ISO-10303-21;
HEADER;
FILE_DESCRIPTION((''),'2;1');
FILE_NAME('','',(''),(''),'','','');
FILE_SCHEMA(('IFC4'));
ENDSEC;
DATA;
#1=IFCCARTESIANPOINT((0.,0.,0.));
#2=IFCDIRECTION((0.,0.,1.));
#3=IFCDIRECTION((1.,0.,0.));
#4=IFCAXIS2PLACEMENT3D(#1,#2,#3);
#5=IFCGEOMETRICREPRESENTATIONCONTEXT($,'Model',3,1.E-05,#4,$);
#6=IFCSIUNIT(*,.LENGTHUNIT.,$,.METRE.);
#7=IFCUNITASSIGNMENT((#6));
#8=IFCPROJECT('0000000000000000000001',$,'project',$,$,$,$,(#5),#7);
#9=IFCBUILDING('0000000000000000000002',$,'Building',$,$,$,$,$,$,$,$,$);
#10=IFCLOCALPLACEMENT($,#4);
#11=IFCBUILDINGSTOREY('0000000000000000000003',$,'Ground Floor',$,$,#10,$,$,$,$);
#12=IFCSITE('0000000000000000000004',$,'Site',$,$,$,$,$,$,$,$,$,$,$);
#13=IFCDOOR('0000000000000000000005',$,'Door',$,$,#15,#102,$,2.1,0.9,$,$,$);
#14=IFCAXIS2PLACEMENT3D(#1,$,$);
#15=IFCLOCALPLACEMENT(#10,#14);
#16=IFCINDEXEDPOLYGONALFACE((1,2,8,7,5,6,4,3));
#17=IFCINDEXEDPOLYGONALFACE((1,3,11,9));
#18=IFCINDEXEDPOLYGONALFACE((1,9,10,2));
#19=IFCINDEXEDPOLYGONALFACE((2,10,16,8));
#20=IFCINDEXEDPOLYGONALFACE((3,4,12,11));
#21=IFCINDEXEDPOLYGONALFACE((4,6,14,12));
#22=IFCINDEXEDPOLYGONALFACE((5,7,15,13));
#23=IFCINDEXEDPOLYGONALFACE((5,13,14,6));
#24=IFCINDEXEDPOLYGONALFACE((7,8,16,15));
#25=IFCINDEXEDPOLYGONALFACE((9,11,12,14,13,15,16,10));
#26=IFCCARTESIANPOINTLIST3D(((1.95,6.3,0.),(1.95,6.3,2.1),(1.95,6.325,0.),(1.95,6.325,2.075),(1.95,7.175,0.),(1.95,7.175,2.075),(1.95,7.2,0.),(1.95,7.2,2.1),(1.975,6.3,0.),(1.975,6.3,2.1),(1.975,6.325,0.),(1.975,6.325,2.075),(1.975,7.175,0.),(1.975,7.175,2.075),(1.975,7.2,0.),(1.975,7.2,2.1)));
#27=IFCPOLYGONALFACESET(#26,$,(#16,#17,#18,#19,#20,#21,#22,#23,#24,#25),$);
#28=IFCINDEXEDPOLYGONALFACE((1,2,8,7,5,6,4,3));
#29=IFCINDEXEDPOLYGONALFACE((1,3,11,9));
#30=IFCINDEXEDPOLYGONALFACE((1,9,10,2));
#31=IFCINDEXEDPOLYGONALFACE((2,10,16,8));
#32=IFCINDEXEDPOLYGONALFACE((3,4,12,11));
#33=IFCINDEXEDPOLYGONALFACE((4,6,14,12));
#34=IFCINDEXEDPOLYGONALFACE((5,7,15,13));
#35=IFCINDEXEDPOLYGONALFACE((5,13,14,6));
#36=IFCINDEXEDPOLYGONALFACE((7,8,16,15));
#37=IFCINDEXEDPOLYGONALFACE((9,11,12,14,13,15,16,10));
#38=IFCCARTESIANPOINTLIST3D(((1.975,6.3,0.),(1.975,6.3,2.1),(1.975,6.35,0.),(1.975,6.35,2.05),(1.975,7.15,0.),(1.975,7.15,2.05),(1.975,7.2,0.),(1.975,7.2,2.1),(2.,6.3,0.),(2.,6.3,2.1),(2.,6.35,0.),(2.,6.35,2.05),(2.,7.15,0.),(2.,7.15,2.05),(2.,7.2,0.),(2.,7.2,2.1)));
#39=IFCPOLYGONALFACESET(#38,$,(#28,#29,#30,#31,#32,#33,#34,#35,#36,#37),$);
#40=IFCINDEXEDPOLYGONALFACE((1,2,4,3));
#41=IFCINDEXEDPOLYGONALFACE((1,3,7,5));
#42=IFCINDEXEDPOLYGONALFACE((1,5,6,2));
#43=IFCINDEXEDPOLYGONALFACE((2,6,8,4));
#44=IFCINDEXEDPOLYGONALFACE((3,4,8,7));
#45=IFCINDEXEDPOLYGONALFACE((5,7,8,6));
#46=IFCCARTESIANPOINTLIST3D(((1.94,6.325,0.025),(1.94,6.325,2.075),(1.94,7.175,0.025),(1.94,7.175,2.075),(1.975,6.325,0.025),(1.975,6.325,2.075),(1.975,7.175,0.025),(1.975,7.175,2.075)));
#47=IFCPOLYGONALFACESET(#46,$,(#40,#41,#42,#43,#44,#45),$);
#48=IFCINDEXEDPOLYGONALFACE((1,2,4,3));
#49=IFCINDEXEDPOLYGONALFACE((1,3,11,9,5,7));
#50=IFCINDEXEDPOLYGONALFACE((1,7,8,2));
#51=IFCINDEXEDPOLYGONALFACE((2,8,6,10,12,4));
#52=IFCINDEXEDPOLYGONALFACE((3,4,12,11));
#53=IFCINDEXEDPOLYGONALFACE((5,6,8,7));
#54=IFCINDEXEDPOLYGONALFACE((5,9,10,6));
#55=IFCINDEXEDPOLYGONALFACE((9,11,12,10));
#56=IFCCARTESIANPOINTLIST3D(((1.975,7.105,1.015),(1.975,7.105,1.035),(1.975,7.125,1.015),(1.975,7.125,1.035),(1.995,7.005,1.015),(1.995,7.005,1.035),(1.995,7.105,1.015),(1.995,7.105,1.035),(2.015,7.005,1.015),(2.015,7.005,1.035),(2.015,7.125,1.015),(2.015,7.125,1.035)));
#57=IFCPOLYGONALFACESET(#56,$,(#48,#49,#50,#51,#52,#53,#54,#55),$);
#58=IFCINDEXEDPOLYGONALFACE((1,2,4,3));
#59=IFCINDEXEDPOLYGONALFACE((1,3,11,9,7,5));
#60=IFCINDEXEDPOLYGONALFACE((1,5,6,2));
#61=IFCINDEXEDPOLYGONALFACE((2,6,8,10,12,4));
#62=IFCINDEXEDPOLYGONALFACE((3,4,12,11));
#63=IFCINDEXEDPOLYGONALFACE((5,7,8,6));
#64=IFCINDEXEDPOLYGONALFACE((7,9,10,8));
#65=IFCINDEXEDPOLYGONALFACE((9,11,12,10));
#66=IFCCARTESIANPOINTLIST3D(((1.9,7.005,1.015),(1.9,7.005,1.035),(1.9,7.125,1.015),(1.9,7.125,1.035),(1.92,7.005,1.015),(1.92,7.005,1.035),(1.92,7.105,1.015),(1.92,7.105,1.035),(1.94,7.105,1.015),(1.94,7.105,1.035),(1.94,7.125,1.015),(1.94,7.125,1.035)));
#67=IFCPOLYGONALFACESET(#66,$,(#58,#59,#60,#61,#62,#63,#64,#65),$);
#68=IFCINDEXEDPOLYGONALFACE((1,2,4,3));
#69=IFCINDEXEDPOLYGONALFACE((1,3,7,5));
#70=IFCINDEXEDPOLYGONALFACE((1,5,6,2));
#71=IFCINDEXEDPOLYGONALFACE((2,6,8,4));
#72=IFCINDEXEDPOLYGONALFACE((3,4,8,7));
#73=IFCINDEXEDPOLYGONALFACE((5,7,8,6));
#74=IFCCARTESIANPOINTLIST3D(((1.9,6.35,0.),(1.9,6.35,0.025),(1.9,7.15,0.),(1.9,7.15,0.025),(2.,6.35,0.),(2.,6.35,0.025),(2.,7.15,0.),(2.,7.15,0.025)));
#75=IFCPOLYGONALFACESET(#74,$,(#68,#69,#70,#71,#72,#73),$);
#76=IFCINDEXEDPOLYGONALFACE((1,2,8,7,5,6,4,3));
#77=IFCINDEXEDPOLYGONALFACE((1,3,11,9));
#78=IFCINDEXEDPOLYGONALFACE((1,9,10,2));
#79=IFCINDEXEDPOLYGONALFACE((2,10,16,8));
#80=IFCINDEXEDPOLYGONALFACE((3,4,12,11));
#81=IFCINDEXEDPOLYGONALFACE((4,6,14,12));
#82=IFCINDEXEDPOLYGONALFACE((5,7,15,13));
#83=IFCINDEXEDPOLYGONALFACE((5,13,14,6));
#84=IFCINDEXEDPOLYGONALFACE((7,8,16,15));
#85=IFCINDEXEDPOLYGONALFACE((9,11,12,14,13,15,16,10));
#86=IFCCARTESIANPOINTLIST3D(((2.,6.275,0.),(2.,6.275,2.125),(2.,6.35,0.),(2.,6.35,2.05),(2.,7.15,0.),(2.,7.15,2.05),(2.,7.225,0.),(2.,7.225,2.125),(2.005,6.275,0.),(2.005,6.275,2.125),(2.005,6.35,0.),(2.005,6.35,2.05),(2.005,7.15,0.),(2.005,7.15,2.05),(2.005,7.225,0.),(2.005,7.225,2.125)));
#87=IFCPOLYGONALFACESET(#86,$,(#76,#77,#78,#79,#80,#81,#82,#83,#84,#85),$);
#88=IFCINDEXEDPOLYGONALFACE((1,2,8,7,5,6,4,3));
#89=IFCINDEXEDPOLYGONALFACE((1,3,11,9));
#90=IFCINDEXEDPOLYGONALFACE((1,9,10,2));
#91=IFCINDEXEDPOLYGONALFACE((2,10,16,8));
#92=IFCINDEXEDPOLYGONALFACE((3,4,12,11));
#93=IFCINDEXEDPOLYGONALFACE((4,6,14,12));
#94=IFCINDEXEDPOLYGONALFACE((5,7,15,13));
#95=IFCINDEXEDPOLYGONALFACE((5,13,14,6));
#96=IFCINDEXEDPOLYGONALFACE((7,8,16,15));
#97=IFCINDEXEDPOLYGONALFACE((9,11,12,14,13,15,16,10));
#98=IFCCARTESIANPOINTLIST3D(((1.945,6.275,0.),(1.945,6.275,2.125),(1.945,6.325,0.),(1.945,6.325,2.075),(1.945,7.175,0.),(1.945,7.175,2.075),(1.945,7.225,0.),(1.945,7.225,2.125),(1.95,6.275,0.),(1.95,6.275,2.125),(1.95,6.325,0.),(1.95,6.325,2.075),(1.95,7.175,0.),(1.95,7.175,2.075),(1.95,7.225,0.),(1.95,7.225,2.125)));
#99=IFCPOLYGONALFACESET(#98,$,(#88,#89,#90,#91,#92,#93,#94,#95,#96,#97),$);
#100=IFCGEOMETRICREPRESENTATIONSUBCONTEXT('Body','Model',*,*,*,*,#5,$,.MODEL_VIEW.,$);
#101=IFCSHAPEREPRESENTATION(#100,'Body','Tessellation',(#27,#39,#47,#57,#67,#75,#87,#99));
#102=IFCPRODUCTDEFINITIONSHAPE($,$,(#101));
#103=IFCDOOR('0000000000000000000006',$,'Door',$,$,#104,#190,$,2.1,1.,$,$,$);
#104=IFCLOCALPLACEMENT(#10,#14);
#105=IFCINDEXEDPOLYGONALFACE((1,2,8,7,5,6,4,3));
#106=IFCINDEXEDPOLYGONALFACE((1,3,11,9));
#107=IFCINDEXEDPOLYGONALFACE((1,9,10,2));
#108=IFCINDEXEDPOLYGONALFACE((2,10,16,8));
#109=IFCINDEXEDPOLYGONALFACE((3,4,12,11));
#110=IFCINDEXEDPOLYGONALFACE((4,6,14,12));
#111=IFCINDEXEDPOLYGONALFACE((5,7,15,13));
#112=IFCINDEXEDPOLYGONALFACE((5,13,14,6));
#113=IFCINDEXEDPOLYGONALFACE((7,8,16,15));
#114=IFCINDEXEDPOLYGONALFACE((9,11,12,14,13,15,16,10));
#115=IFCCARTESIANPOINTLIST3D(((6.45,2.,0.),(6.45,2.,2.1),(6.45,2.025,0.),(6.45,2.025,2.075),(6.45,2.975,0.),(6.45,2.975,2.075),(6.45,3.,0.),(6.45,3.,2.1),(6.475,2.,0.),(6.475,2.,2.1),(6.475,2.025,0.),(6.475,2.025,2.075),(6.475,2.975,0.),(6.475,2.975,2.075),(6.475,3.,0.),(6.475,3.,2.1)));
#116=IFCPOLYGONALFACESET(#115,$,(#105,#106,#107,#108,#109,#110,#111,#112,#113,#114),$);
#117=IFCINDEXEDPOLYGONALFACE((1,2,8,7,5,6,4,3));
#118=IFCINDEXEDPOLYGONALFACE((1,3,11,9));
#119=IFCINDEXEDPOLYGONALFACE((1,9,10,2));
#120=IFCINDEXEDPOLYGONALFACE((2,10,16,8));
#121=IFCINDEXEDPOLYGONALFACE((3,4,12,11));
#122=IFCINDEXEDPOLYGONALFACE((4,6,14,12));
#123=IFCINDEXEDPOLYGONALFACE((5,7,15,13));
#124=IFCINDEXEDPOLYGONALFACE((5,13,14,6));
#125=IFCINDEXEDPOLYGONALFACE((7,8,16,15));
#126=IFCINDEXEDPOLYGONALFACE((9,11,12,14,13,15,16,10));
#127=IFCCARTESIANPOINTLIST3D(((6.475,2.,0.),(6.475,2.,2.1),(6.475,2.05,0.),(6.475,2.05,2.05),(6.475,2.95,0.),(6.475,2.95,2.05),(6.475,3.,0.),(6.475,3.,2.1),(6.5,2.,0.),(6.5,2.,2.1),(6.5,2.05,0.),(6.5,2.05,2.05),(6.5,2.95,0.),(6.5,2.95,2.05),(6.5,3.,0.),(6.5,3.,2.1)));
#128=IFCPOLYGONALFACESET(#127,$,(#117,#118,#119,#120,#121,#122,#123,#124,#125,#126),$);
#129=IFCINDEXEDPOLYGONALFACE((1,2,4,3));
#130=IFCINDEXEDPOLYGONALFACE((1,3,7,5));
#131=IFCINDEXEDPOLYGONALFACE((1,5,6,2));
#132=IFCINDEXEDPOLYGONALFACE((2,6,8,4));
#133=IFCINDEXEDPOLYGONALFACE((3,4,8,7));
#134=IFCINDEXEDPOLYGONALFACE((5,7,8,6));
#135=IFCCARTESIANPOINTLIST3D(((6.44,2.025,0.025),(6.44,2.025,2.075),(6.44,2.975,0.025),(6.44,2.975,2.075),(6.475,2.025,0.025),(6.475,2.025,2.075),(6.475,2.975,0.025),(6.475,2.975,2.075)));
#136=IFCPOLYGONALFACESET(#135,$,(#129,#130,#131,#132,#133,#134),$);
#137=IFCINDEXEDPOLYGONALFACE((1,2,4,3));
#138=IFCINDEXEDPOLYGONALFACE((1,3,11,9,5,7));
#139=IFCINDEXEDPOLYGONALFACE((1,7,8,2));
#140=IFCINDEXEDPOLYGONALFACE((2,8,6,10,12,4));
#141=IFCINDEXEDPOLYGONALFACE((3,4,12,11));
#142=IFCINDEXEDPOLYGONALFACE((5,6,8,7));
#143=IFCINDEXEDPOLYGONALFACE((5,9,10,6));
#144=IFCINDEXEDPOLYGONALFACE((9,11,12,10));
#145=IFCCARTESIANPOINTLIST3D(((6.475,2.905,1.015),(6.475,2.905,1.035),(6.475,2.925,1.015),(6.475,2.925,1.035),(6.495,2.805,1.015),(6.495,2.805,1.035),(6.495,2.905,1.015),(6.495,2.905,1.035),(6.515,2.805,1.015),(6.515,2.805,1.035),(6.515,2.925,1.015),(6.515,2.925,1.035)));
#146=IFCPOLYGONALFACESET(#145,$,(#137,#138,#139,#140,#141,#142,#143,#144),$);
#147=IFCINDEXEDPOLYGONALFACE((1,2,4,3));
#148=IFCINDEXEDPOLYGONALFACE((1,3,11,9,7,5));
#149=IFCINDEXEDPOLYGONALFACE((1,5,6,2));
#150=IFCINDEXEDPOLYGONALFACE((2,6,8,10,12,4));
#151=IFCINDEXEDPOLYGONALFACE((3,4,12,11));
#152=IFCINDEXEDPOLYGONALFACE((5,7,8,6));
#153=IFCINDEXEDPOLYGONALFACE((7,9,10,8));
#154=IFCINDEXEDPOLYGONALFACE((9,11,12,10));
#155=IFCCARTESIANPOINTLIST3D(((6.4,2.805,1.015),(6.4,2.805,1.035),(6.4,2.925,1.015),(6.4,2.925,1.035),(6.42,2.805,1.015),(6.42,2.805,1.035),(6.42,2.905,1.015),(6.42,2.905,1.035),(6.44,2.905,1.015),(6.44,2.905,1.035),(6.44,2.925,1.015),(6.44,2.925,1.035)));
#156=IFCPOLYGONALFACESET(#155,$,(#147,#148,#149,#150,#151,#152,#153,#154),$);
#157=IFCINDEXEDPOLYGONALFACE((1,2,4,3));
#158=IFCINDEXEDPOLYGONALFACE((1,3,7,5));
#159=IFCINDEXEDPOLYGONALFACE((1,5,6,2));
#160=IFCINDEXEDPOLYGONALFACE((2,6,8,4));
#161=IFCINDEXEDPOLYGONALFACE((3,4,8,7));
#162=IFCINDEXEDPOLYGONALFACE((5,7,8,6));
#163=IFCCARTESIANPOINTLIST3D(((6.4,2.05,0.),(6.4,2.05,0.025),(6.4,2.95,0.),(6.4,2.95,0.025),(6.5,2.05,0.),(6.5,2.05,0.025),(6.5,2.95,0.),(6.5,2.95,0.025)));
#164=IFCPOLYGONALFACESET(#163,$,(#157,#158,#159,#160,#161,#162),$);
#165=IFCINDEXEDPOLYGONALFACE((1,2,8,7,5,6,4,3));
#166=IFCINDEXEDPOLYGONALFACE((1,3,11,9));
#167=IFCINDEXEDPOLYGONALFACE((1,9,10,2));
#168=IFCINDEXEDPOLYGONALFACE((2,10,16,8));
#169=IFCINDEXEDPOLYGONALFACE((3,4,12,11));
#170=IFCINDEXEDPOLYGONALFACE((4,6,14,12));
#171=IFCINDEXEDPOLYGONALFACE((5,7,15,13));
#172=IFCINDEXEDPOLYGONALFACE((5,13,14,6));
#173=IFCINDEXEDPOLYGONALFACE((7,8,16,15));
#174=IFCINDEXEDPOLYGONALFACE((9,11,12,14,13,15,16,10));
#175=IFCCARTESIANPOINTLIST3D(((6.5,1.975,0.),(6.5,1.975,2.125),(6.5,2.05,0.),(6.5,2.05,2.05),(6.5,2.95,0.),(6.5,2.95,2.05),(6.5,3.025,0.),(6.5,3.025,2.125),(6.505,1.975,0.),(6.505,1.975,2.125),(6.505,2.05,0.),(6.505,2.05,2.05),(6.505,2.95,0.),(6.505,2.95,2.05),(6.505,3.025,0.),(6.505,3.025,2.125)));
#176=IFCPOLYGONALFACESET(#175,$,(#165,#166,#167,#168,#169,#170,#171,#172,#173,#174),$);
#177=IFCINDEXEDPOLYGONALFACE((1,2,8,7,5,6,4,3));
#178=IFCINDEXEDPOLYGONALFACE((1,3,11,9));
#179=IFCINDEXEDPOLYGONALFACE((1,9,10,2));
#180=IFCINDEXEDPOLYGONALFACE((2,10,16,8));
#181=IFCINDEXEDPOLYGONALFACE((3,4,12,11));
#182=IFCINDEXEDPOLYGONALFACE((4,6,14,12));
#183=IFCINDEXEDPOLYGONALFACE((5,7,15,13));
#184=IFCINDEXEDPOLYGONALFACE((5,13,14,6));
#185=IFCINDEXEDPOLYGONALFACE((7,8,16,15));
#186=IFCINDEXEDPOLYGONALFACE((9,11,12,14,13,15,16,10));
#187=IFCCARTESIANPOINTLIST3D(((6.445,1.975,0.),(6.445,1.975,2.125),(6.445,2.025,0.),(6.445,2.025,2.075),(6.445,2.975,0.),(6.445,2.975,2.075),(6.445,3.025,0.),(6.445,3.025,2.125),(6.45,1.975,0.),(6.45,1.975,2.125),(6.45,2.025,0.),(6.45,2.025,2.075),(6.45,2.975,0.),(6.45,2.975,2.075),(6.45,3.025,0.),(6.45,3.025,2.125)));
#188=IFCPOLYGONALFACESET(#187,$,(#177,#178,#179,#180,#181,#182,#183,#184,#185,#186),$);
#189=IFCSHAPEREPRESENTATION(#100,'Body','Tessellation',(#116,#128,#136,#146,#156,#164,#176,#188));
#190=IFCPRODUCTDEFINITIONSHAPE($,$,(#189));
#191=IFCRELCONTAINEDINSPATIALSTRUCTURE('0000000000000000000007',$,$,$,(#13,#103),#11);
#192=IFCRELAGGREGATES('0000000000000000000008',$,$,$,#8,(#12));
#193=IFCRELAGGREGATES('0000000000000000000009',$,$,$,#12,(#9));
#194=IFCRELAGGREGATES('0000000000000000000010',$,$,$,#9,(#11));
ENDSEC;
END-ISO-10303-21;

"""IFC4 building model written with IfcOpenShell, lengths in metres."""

from ifc_helpers import new_model, si_unit, frame, origin_with_axes, place, context, subcontext, project, spatial, line, indexed_curve, outline, extrude, element, save


model = new_model("IFC4")

# Units and contexts
model_context = context("Model", 3, precision=1e-05, world=origin_with_axes())
body_context = subcontext(model_context, "Body", "Model", "MODEL_VIEW")
ifc_project = project(units=[si_unit("LENGTHUNIT", "METRE")], contexts=[model_context])

# Site, building, storey
site = spatial("IfcSite", under=ifc_project, Name="Site")
building = spatial("IfcBuilding", under=site, Name="Building")
storey_placement = place(None, origin_with_axes())
storey = spatial("IfcBuildingStorey", under=building, at=storey_placement, Name="Ground Floor")

# Doors
door_1_placement = place(storey_placement, frame((2.0, 6.3, 0.0), z_axis=(0.0, 0.0, 1.0), x_axis=(0.0, 1.0, 0.0)))
element("IfcDoor", 1, at=door_1_placement, inside=storey, Name="Door", OverallHeight=2.1, OverallWidth=0.9, context=body_context, shape_type="SweptSolid", body=[
    extrude(outline(indexed_curve([(0.0, 0.0), (0.0, 2.1), (0.9, 2.1), (0.9, 0.0), (0.875, 0.0), (0.875, 2.075), (0.025, 2.075), (0.025, 0.0)], segments=[line(1, 2, 3, 4, 5, 6, 7, 8, 1)])), frame((0.0, 0.025, 0.0), z_axis=(0.0, -1.0, 0.0), x_axis=(1.0, 0.0, 0.0)), (0.0, 0.0, -1.0), 0.025),
    extrude(outline(indexed_curve([(0.0, 0.0), (0.0, 2.1), (0.9, 2.1), (0.9, 0.0), (0.85, 0.0), (0.85, 2.05), (0.05, 2.05), (0.05, 0.0)], segments=[line(1, 2, 3, 4, 5, 6, 7, 8, 1)])), frame((0.0, 0.0, 0.0), z_axis=(0.0, -1.0, 0.0), x_axis=(1.0, 0.0, 0.0)), (0.0, 0.0, -1.0), 0.025),
    extrude(outline(indexed_curve([(0.0, 0.0), (0.85, 0.0), (0.85, 0.035), (0.0, 0.035)], segments=[line(1, 2, 3, 4, 1)])), frame((0.025, 0.025, 0.025), z_axis=(0.0, 0.0, 1.0), x_axis=(1.0, 0.0, 0.0)), (0.0, 0.0, 1.0), 2.05),
    extrude(outline(indexed_curve([(0.0, 0.0), (0.0, -0.04), (-0.12, -0.04), (-0.12, -0.02), (-0.02, -0.02), (-0.02, 0.0)], segments=[line(1, 2, 3, 4, 5, 6, 1)])), frame((0.825, 0.025, 1.015), z_axis=(0.0, 0.0, 1.0), x_axis=(1.0, 0.0, 0.0)), (0.0, 0.0, 1.0), 0.02),
    extrude(outline(indexed_curve([(0.0, 0.0), (0.0, 0.04), (-0.12, 0.04), (-0.12, 0.02), (-0.02, 0.02), (-0.02, 0.0)], segments=[line(1, 2, 3, 4, 5, 6, 1)])), frame((0.825, 0.06, 1.015), z_axis=(0.0, 0.0, 1.0), x_axis=(1.0, 0.0, 0.0)), (0.0, 0.0, 1.0), 0.02),
    extrude(outline(indexed_curve([(0.0, 0.0), (0.8, 0.0), (0.8, 0.1), (0.0, 0.1)], segments=[line(1, 2, 3, 4, 1)])), frame((0.05, 0.0, 0.0), z_axis=(0.0, 0.0, 1.0), x_axis=(1.0, 0.0, 0.0)), (0.0, 0.0, 1.0), 0.025),
    extrude(outline(indexed_curve([(0.0, 0.0), (0.0, 2.125), (0.95, 2.125), (0.95, 0.0), (0.875, 0.0), (0.875, 2.05), (0.075, 2.05), (0.075, 0.0)], segments=[line(1, 2, 3, 4, 5, 6, 7, 8, 1)])), frame((-0.025, -0.005, 0.0), z_axis=(0.0, -1.0, 0.0), x_axis=(1.0, 0.0, 0.0)), (0.0, 0.0, -1.0), 0.005),
    extrude(outline(indexed_curve([(0.0, 0.0), (0.0, 2.125), (0.95, 2.125), (0.95, 0.0), (0.9, 0.0), (0.9, 2.075), (0.05, 2.075), (0.05, 0.0)], segments=[line(1, 2, 3, 4, 5, 6, 7, 8, 1)])), frame((-0.025, 0.05, 0.0), z_axis=(0.0, -1.0, 0.0), x_axis=(1.0, 0.0, 0.0)), (0.0, 0.0, -1.0), 0.005),
])
door_2_placement = place(storey_placement, frame((6.5, 2.0, 0.0), z_axis=(0.0, 0.0, 1.0), x_axis=(0.0, 1.0, 0.0)))
element("IfcDoor", 2, at=door_2_placement, inside=storey, Name="Door", OverallHeight=2.1, OverallWidth=1.0, context=body_context, shape_type="SweptSolid", body=[
    extrude(outline(indexed_curve([(0.0, 0.0), (0.0, 2.1), (1.0, 2.1), (1.0, 0.0), (0.975, 0.0), (0.975, 2.075), (0.025, 2.075), (0.025, 0.0)], segments=[line(1, 2, 3, 4, 5, 6, 7, 8, 1)])), frame((0.0, 0.025, 0.0), z_axis=(0.0, -1.0, 0.0), x_axis=(1.0, 0.0, 0.0)), (0.0, 0.0, -1.0), 0.025),
    extrude(outline(indexed_curve([(0.0, 0.0), (0.0, 2.1), (1.0, 2.1), (1.0, 0.0), (0.95, 0.0), (0.95, 2.05), (0.05, 2.05), (0.05, 0.0)], segments=[line(1, 2, 3, 4, 5, 6, 7, 8, 1)])), frame((0.0, 0.0, 0.0), z_axis=(0.0, -1.0, 0.0), x_axis=(1.0, 0.0, 0.0)), (0.0, 0.0, -1.0), 0.025),
    extrude(outline(indexed_curve([(0.0, 0.0), (0.95, 0.0), (0.95, 0.035), (0.0, 0.035)], segments=[line(1, 2, 3, 4, 1)])), frame((0.025, 0.025, 0.025), z_axis=(0.0, 0.0, 1.0), x_axis=(1.0, 0.0, 0.0)), (0.0, 0.0, 1.0), 2.05),
    extrude(outline(indexed_curve([(0.0, 0.0), (0.0, -0.04), (-0.12, -0.04), (-0.12, -0.02), (-0.02, -0.02), (-0.02, 0.0)], segments=[line(1, 2, 3, 4, 5, 6, 1)])), frame((0.925, 0.025, 1.015), z_axis=(0.0, 0.0, 1.0), x_axis=(1.0, 0.0, 0.0)), (0.0, 0.0, 1.0), 0.02),
    extrude(outline(indexed_curve([(0.0, 0.0), (0.0, 0.04), (-0.12, 0.04), (-0.12, 0.02), (-0.02, 0.02), (-0.02, 0.0)], segments=[line(1, 2, 3, 4, 5, 6, 1)])), frame((0.925, 0.06, 1.015), z_axis=(0.0, 0.0, 1.0), x_axis=(1.0, 0.0, 0.0)), (0.0, 0.0, 1.0), 0.02),
    extrude(outline(indexed_curve([(0.0, 0.0), (0.9, 0.0), (0.9, 0.1), (0.0, 0.1)], segments=[line(1, 2, 3, 4, 1)])), frame((0.05, 0.0, 0.0), z_axis=(0.0, 0.0, 1.0), x_axis=(1.0, 0.0, 0.0)), (0.0, 0.0, 1.0), 0.025),
    extrude(outline(indexed_curve([(0.0, 0.0), (0.0, 2.125), (1.05, 2.125), (1.05, 0.0), (0.975, 0.0), (0.975, 2.05), (0.075, 2.05), (0.075, 0.0)], segments=[line(1, 2, 3, 4, 5, 6, 7, 8, 1)])), frame((-0.025, -0.005, 0.0), z_axis=(0.0, -1.0, 0.0), x_axis=(1.0, 0.0, 0.0)), (0.0, 0.0, -1.0), 0.005),
    extrude(outline(indexed_curve([(0.0, 0.0), (0.0, 2.125), (1.05, 2.125), (1.05, 0.0), (1.0, 0.0), (1.0, 2.075), (0.05, 2.075), (0.05, 0.0)], segments=[line(1, 2, 3, 4, 5, 6, 7, 8, 1)])), frame((-0.025, 0.05, 0.0), z_axis=(0.0, -1.0, 0.0), x_axis=(1.0, 0.0, 0.0)), (0.0, 0.0, -1.0), 0.005),
])

save(model, "model.ifc")
